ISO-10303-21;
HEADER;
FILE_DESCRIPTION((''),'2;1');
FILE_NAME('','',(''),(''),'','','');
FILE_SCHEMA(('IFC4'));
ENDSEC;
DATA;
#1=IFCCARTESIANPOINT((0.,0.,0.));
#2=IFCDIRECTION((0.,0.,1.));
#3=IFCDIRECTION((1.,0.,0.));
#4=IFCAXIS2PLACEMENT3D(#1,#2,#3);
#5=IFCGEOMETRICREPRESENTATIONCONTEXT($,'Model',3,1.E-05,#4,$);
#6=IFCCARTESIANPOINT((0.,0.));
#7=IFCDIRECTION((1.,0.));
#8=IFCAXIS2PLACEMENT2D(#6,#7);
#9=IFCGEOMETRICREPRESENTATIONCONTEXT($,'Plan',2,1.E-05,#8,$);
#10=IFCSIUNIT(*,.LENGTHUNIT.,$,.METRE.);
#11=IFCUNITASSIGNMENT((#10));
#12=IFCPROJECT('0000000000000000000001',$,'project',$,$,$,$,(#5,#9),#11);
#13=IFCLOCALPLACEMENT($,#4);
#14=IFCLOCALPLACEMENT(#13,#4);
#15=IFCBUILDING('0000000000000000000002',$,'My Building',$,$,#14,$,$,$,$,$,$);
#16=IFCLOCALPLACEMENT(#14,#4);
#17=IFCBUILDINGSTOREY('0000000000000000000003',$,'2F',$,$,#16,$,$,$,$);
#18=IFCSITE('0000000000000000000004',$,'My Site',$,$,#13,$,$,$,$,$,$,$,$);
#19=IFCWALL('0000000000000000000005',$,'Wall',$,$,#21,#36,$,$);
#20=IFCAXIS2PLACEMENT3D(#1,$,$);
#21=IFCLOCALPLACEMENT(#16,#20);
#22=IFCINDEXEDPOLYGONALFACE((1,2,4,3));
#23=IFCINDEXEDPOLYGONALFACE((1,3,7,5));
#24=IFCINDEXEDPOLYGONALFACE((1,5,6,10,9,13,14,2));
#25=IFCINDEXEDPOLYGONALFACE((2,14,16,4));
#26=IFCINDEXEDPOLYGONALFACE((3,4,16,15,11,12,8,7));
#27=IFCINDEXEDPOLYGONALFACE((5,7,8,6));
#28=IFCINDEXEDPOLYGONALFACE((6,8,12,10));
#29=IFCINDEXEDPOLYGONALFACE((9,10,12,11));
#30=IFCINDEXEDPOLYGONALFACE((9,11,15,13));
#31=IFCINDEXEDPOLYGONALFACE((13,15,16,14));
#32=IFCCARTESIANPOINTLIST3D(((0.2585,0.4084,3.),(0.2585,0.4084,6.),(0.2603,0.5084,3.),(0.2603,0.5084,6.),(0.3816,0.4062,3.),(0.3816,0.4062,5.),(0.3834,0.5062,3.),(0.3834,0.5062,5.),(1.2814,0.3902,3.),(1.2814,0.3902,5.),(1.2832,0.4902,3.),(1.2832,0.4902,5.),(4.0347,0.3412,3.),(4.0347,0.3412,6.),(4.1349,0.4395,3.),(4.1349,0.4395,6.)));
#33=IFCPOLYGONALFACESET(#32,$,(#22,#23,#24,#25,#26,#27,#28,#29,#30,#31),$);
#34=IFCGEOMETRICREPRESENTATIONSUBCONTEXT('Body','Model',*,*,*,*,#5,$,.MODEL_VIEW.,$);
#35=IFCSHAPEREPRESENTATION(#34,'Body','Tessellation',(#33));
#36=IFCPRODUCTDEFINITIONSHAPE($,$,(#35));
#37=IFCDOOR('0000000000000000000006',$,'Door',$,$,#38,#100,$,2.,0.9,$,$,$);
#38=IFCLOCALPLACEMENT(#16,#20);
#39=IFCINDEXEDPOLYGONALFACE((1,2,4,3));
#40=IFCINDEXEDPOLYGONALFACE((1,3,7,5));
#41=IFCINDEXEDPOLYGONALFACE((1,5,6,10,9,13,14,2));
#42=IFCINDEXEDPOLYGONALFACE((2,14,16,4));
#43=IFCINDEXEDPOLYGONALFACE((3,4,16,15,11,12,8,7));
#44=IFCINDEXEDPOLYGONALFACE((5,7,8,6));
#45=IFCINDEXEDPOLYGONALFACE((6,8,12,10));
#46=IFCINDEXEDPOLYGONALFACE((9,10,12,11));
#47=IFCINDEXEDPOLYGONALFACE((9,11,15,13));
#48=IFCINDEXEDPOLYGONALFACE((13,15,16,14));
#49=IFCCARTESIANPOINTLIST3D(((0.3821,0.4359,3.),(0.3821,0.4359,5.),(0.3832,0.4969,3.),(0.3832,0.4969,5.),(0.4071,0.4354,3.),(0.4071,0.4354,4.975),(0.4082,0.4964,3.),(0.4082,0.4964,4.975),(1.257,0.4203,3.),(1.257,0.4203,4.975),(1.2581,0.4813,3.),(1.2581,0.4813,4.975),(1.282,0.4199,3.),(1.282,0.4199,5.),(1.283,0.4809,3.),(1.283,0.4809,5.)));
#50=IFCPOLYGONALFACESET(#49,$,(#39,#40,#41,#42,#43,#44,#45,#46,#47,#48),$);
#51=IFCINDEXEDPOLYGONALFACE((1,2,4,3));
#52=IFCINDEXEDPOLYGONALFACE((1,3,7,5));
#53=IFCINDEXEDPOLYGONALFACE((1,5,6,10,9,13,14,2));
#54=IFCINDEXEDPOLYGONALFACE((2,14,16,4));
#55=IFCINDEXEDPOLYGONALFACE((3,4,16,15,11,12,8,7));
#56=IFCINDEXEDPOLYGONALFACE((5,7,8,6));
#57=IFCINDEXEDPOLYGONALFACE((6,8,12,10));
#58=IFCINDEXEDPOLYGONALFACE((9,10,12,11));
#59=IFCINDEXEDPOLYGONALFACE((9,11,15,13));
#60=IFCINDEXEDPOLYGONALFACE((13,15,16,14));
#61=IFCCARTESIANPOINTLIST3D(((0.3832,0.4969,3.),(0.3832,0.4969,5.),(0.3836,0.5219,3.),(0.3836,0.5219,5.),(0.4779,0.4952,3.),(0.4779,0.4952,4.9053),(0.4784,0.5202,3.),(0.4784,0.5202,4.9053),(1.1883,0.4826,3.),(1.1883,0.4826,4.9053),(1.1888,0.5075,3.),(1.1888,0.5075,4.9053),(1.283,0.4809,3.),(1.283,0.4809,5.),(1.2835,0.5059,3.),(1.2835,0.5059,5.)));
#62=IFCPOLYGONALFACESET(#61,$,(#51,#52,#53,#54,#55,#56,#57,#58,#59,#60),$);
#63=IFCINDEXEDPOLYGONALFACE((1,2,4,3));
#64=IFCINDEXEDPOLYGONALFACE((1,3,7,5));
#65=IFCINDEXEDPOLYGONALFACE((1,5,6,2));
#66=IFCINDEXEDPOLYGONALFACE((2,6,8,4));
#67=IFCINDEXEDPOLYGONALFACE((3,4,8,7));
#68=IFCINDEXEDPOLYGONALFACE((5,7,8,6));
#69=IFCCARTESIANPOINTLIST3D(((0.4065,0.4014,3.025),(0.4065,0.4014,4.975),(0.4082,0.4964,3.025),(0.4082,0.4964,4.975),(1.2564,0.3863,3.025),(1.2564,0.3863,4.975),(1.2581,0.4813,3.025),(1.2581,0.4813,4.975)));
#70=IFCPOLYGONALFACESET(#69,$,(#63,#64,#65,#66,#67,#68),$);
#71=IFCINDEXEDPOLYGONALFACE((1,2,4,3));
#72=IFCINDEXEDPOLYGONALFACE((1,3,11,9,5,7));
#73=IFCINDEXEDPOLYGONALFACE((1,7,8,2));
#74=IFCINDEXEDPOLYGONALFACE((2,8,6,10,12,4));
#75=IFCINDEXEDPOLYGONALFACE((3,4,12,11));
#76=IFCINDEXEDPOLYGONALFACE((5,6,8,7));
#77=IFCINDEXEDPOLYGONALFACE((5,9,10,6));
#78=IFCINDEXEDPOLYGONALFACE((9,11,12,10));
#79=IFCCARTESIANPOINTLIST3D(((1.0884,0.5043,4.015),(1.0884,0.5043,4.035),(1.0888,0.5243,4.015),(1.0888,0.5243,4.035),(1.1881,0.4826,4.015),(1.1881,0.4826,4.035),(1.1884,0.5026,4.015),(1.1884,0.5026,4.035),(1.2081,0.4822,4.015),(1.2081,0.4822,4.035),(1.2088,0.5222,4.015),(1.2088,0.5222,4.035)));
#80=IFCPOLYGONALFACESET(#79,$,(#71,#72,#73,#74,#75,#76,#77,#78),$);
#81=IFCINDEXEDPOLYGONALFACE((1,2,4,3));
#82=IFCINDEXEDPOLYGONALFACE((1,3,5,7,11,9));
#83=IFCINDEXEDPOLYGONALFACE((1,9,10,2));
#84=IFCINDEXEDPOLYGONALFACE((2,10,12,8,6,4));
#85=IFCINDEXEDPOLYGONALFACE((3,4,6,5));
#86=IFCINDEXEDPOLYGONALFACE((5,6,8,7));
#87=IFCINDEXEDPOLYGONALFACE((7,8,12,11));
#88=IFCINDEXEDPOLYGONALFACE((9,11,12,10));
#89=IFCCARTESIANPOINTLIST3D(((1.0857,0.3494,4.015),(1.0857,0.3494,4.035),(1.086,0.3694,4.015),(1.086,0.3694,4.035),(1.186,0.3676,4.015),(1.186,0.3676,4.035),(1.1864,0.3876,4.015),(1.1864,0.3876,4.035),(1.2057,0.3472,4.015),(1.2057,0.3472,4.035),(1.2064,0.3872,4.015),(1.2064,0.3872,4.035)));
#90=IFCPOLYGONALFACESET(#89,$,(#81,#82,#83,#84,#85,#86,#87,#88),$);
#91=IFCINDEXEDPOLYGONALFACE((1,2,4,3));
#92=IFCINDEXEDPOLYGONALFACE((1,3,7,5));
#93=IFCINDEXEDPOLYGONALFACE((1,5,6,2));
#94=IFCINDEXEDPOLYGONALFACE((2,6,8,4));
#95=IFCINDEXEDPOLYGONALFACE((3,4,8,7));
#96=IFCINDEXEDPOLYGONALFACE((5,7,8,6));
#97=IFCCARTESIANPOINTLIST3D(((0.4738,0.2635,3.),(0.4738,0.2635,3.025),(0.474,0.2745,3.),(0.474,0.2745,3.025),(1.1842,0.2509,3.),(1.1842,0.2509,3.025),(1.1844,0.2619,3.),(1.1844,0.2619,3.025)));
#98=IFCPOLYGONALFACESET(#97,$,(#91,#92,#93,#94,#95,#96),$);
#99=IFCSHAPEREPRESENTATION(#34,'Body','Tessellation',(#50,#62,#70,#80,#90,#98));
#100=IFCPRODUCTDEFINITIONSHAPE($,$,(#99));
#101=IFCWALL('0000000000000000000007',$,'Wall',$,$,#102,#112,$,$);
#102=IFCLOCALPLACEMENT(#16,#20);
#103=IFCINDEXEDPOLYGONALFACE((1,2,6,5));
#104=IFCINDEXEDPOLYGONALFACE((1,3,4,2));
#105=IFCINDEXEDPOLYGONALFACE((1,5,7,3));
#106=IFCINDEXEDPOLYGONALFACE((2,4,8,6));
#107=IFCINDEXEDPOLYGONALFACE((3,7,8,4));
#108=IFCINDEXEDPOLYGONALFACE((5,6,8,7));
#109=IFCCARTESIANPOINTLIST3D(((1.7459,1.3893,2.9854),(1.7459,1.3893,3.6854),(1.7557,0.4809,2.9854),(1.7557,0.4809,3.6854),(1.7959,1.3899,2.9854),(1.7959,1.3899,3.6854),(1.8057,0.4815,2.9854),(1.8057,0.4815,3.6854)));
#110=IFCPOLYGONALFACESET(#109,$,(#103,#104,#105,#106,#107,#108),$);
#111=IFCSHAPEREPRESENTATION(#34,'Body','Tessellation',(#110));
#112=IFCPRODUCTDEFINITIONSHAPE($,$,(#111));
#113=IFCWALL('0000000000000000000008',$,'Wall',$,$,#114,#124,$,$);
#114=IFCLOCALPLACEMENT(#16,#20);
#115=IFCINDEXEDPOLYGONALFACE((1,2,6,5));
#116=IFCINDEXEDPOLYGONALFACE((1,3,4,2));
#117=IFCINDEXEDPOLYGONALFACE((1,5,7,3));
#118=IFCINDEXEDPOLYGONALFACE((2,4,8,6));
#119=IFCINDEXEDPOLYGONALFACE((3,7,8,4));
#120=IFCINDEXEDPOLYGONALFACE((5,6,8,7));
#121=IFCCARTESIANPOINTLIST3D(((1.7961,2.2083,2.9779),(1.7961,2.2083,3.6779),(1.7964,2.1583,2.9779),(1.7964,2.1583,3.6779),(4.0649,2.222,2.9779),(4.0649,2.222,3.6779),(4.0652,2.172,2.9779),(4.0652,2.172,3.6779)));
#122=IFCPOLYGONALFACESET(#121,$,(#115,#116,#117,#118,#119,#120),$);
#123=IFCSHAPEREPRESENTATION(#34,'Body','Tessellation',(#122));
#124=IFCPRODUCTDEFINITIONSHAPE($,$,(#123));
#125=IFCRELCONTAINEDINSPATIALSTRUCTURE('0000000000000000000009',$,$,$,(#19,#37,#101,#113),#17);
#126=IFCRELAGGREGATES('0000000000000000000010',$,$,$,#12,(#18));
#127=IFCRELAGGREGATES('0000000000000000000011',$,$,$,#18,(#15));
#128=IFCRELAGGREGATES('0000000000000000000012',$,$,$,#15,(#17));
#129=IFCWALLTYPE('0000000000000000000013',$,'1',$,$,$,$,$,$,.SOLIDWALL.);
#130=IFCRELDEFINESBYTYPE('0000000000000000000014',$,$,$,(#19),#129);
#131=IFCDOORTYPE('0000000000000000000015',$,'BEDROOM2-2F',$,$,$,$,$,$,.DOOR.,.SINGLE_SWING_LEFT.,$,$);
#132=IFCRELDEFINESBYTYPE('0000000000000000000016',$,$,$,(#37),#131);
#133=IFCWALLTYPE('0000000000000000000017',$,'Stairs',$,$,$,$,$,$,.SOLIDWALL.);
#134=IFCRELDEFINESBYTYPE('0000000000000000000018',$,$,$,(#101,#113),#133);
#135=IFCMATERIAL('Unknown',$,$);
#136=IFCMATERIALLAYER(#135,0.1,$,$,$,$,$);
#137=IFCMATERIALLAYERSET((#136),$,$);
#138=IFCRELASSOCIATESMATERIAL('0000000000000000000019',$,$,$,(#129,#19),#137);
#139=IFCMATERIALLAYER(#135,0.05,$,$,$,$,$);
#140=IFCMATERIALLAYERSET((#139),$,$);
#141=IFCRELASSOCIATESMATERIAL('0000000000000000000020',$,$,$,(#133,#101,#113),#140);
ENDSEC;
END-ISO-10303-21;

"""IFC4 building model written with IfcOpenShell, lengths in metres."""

from ifc_helpers import new_model, entity, si_unit, frame, origin_with_axes, origin_2d_with_axis, place, context, subcontext, project, spatial, line, indexed_curve, outline, extrude, shape, source, transform, mapped, material, layer, layer_set, layer_usage, type_object, type_shapes, element, fill, save


model = new_model("IFC4")

# Units and contexts
model_context = context("Model", 3, precision=1e-05, world=origin_with_axes())
plan_context = context("Plan", 2, precision=1e-05, world=origin_2d_with_axis())
body_context_1 = subcontext(model_context, "Body", "Model", "MODEL_VIEW")
body_context_2 = subcontext(plan_context, "Body", "Plan", "PLAN_VIEW")
ifc_project = project(units=[si_unit("LENGTHUNIT", "METRE")], contexts=[model_context, plan_context])

# Site, building, storey
site_placement = place(None, origin_with_axes())
site = spatial("IfcSite", under=ifc_project, at=site_placement, Name="My Site")
building_placement = place(site_placement, origin_with_axes())
building = spatial("IfcBuilding", under=site, at=building_placement, Name="My Building")
storey_placement = place(building_placement, origin_with_axes())
storey = spatial("IfcBuildingStorey", under=building, at=storey_placement, Name="2F")

# Shared definitions
ifc_material = material(Name="Unknown")

# Wall, opening, door
ifc_layer_1 = layer(ifc_material, 0.1)
ifc_layer_set_1 = layer_set([ifc_layer_1])
wall_type_1 = type_object("IfcWallType", Name="1", PredefinedType="SOLIDWALL", material=ifc_layer_set_1)
ifc_layer_usage_1 = layer_usage(ifc_layer_set_1, "AXIS2", "POSITIVE", 0.0)
wall_1_placement = place(storey_placement, frame((0.2585, 0.4084, 3.0), z_axis=(0.0, 0.0, 1.0), x_axis=(0.999842, -0.017775, 0.0)))
wall_1 = element("IfcWall", 1, at=wall_1_placement, inside=storey, type_object=wall_type_1, material=ifc_layer_usage_1, Name="Wall", context=body_context_1, shape_type="SweptSolid", body=[
    extrude(outline(indexed_curve([(0.0, 0.0), (0.0, 0.1), (3.8752, 0.1), (3.7768, 0.0)], segments=[line(1, 2, 3, 4, 1)])), origin_with_axes(), (0.0, 0.0, 1.0), 3.0),
])
shared_shape_1 = source(origin_with_axes(), body_context_1, "Body", "SweptSolid", [
    extrude(outline(indexed_curve([(0.0, 0.0), (0.9, 0.0), (0.9, 2.0), (0.0, 2.0)], segments=[line(1, 2, 3, 4, 1)])), frame((0.0, -0.6, 0.0), z_axis=(0.0, -1.0, 0.0), x_axis=(1.0, 0.0, 0.0)), (0.0, 0.0, -1.0), 1.2),
])
opening_1_placement = place(wall_1_placement, frame((1.0231, 0.1, 0.0), z_axis=(0.0, 0.0, 1.0), x_axis=(-1.0, 0.0, 0.0)))
opening_1 = element("IfcOpeningElement", 2, at=opening_1_placement, cuts=wall_1, PredefinedType="OPENING", context=body_context_1, shape_type="MappedRepresentation", body=[
    mapped(shared_shape_1, transform((0.0, 0.0, 0.0), x_axis=(1.0, 0.0, 0.0), y_axis=(0.0, 1.0, 0.0), z_axis=(0.0, 0.0, 1.0), scale=1.0)),
])
door_type_1 = type_object("IfcDoorType", Name="BEDROOM2-2F", OperationType="SINGLE_SWING_LEFT", PredefinedType="DOOR")
shared_shape_2 = source(origin_with_axes(), body_context_1, "Body", "SweptSolid", [
    extrude(outline(indexed_curve([(0.0, 0.0), (0.0, 2.0), (0.9, 2.0), (0.9, 0.0), (0.875, 0.0), (0.875, 1.975), (0.025, 1.975), (0.025, 0.0)], segments=[line(1, 2, 3, 4, 5, 6, 7, 8, 1)])), frame((0.0, 0.0093, 0.0), z_axis=(0.0, -1.0, 0.0), x_axis=(1.0, 0.0, 0.0)), (0.0, 0.0, -1.0), 0.061),
    extrude(outline(indexed_curve([(0.0, 0.0), (0.0, 2.0), (0.9, 2.0), (0.9, 0.0), (0.8053, 0.0), (0.8053, 1.9053), (0.0947, 1.9053), (0.0947, 0.0)], segments=[line(1, 2, 3, 4, 5, 6, 7, 8, 1)])), frame((0.0, -0.0157, 0.0), z_axis=(0.0, -1.0, 0.0), x_axis=(1.0, 0.0, 0.0)), (0.0, 0.0, -1.0), 0.025),
    extrude(outline(indexed_curve([(0.0, 0.0), (0.85, 0.0), (0.85, 0.095), (0.0, 0.095)], segments=[line(1, 2, 3, 4, 1)])), frame((0.025, 0.0093, 0.025), z_axis=(0.0, 0.0, 1.0), x_axis=(1.0, 0.0, 0.0)), (0.0, 0.0, 1.0), 1.95),
    extrude(outline(indexed_curve([(0.0, 0.0), (0.0, -0.04), (0.12, -0.04), (0.12, -0.02), (0.02, -0.02), (0.02, 0.0)], segments=[line(1, 2, 3, 4, 5, 6, 1)])), frame((0.075, 0.0093, 1.015), z_axis=(0.0, 0.0, 1.0), x_axis=(1.0, 0.0, 0.0)), (0.0, 0.0, 1.0), 0.02),
    extrude(outline(indexed_curve([(0.0, 0.0), (0.0, 0.04), (0.12, 0.04), (0.12, 0.02), (0.02, 0.02), (0.02, 0.0)], segments=[line(1, 2, 3, 4, 5, 6, 1)])), frame((0.075, 0.1043, 1.015), z_axis=(0.0, 0.0, 1.0), x_axis=(1.0, 0.0, 0.0)), (0.0, 0.0, 1.0), 0.02),
    extrude(outline(indexed_curve([(0.0, 0.0), (0.7105, 0.0), (0.7105, 0.011), (0.0, 0.011)], segments=[line(1, 2, 3, 4, 1)])), frame((0.0947, 0.23, 0.0), z_axis=(0.0, 0.0, 1.0), x_axis=(1.0, 0.0, 0.0)), (0.0, 0.0, 1.0), 0.025),
])
shared_shape_3 = source(origin_with_axes(), body_context_2, "Body", "Curve2D", [
    entity("IfcIndexedPolyCurve", entity("IfcCartesianPointList2D", [[0.0, -0.0157], [0.0, 0.0703], [0.025, 0.0703], [0.025, 0.0093], [0.0947, 0.0093], [0.0947, -0.0157]]), [entity("IfcLineIndex", [1, 2, 3, 4, 5, 6, 1])]),
    entity("IfcIndexedPolyCurve", entity("IfcCartesianPointList2D", [[0.9, -0.0157], [0.9, 0.0703], [0.875, 0.0703], [0.875, 0.0093], [0.8053, 0.0093], [0.8053, -0.0157]]), [entity("IfcLineIndex", [1, 2, 3, 4, 5, 6, 1])]),
    entity("IfcTrimmedCurve", entity("IfcEllipse", entity("IfcAxis2Placement2D", entity("IfcCartesianPoint", [0.78, 0.0703]), entity("IfcDirection", [1.0, 0.0])), 0.755, 0.85), [entity("IfcCartesianPoint", [0.78, 0.9203])], [entity("IfcCartesianPoint", [0.025, 0.0703])], True, "CARTESIAN"),
    entity("IfcIndexedPolyCurve", entity("IfcCartesianPointList2D", [[0.875, 0.0703], [0.78, 0.0703], [0.78, 0.9203], [0.875, 0.9203]]), [entity("IfcLineIndex", [1, 2, 3, 4, 1])]),
])
type_shapes(door_type_1, [shared_shape_2, shared_shape_3])
door_1_placement = place(opening_1_placement, frame((0.0, 0.0, 0.0), z_axis=(0.0, 0.0, 1.0), x_axis=(1.0, 0.0, 0.0)))
door_1 = element("IfcDoor", 3, at=door_1_placement, inside=storey, type_object=door_type_1, Name="Door", OverallHeight=2.0, OverallWidth=0.9, shapes=[
    shape(body_context_1, "Body", "MappedRepresentation", [mapped(shared_shape_2, transform((0.0, 0.0, 0.0), x_axis=(1.0, 0.0, 0.0), y_axis=(0.0, 1.0, 0.0), z_axis=(0.0, 0.0, 1.0), scale=1.0))]),
    shape(body_context_2, "Body", "MappedRepresentation", [mapped(shared_shape_3, transform((0.0, 0.0, 0.0), x_axis=(1.0, 0.0, 0.0), y_axis=(0.0, 1.0, 0.0), z_axis=(0.0, 0.0, 1.0), scale=1.0))]),
])
fill(opening_1, door_1)

# Walls
ifc_layer_2 = layer(ifc_material, 0.05)
ifc_layer_set_2 = layer_set([ifc_layer_2])
ifc_layer_usage_2 = layer_usage(ifc_layer_set_2, "AXIS2", "POSITIVE", 0.0)
wall_type_2 = type_object("IfcWallType", Name="Stairs", PredefinedType="SOLIDWALL", material=ifc_layer_set_2)
wall_2_placement = place(storey_placement, frame((1.7459, 1.3893, 2.9854), z_axis=(0.0, 0.0, 1.0), x_axis=(0.010753, -0.999942, 0.0)))
element("IfcWall", 4, at=wall_2_placement, inside=storey, type_object=wall_type_2, material=ifc_layer_usage_2, Name="Wall", context=body_context_1, shape_type="SweptSolid", body=[
    extrude(outline(indexed_curve([(0.0, 0.0), (0.0, 0.05), (0.9085, 0.05), (0.9085, 0.0)], segments=[line(1, 2, 3, 4, 1)])), origin_with_axes(), (0.0, 0.0, 1.0), 0.7),
])
ifc_layer_usage_3 = layer_usage(ifc_layer_set_2, "AXIS2", "POSITIVE", 0.0)
wall_3_placement = place(storey_placement, frame((1.7964, 2.1583, 2.9779), z_axis=(0.0, 0.0, 1.0), x_axis=(0.999982, 0.006065, 0.0)))
element("IfcWall", 5, at=wall_3_placement, inside=storey, type_object=wall_type_2, material=ifc_layer_usage_3, Name="Wall", context=body_context_1, shape_type="SweptSolid", body=[
    extrude(outline(indexed_curve([(0.0, 0.0), (0.0, 0.05), (2.2689, 0.05), (2.2689, 0.0)], segments=[line(1, 2, 3, 4, 1)])), origin_with_axes(), (0.0, 0.0, 1.0), 0.7),
])

save(model, "model.ifc")
